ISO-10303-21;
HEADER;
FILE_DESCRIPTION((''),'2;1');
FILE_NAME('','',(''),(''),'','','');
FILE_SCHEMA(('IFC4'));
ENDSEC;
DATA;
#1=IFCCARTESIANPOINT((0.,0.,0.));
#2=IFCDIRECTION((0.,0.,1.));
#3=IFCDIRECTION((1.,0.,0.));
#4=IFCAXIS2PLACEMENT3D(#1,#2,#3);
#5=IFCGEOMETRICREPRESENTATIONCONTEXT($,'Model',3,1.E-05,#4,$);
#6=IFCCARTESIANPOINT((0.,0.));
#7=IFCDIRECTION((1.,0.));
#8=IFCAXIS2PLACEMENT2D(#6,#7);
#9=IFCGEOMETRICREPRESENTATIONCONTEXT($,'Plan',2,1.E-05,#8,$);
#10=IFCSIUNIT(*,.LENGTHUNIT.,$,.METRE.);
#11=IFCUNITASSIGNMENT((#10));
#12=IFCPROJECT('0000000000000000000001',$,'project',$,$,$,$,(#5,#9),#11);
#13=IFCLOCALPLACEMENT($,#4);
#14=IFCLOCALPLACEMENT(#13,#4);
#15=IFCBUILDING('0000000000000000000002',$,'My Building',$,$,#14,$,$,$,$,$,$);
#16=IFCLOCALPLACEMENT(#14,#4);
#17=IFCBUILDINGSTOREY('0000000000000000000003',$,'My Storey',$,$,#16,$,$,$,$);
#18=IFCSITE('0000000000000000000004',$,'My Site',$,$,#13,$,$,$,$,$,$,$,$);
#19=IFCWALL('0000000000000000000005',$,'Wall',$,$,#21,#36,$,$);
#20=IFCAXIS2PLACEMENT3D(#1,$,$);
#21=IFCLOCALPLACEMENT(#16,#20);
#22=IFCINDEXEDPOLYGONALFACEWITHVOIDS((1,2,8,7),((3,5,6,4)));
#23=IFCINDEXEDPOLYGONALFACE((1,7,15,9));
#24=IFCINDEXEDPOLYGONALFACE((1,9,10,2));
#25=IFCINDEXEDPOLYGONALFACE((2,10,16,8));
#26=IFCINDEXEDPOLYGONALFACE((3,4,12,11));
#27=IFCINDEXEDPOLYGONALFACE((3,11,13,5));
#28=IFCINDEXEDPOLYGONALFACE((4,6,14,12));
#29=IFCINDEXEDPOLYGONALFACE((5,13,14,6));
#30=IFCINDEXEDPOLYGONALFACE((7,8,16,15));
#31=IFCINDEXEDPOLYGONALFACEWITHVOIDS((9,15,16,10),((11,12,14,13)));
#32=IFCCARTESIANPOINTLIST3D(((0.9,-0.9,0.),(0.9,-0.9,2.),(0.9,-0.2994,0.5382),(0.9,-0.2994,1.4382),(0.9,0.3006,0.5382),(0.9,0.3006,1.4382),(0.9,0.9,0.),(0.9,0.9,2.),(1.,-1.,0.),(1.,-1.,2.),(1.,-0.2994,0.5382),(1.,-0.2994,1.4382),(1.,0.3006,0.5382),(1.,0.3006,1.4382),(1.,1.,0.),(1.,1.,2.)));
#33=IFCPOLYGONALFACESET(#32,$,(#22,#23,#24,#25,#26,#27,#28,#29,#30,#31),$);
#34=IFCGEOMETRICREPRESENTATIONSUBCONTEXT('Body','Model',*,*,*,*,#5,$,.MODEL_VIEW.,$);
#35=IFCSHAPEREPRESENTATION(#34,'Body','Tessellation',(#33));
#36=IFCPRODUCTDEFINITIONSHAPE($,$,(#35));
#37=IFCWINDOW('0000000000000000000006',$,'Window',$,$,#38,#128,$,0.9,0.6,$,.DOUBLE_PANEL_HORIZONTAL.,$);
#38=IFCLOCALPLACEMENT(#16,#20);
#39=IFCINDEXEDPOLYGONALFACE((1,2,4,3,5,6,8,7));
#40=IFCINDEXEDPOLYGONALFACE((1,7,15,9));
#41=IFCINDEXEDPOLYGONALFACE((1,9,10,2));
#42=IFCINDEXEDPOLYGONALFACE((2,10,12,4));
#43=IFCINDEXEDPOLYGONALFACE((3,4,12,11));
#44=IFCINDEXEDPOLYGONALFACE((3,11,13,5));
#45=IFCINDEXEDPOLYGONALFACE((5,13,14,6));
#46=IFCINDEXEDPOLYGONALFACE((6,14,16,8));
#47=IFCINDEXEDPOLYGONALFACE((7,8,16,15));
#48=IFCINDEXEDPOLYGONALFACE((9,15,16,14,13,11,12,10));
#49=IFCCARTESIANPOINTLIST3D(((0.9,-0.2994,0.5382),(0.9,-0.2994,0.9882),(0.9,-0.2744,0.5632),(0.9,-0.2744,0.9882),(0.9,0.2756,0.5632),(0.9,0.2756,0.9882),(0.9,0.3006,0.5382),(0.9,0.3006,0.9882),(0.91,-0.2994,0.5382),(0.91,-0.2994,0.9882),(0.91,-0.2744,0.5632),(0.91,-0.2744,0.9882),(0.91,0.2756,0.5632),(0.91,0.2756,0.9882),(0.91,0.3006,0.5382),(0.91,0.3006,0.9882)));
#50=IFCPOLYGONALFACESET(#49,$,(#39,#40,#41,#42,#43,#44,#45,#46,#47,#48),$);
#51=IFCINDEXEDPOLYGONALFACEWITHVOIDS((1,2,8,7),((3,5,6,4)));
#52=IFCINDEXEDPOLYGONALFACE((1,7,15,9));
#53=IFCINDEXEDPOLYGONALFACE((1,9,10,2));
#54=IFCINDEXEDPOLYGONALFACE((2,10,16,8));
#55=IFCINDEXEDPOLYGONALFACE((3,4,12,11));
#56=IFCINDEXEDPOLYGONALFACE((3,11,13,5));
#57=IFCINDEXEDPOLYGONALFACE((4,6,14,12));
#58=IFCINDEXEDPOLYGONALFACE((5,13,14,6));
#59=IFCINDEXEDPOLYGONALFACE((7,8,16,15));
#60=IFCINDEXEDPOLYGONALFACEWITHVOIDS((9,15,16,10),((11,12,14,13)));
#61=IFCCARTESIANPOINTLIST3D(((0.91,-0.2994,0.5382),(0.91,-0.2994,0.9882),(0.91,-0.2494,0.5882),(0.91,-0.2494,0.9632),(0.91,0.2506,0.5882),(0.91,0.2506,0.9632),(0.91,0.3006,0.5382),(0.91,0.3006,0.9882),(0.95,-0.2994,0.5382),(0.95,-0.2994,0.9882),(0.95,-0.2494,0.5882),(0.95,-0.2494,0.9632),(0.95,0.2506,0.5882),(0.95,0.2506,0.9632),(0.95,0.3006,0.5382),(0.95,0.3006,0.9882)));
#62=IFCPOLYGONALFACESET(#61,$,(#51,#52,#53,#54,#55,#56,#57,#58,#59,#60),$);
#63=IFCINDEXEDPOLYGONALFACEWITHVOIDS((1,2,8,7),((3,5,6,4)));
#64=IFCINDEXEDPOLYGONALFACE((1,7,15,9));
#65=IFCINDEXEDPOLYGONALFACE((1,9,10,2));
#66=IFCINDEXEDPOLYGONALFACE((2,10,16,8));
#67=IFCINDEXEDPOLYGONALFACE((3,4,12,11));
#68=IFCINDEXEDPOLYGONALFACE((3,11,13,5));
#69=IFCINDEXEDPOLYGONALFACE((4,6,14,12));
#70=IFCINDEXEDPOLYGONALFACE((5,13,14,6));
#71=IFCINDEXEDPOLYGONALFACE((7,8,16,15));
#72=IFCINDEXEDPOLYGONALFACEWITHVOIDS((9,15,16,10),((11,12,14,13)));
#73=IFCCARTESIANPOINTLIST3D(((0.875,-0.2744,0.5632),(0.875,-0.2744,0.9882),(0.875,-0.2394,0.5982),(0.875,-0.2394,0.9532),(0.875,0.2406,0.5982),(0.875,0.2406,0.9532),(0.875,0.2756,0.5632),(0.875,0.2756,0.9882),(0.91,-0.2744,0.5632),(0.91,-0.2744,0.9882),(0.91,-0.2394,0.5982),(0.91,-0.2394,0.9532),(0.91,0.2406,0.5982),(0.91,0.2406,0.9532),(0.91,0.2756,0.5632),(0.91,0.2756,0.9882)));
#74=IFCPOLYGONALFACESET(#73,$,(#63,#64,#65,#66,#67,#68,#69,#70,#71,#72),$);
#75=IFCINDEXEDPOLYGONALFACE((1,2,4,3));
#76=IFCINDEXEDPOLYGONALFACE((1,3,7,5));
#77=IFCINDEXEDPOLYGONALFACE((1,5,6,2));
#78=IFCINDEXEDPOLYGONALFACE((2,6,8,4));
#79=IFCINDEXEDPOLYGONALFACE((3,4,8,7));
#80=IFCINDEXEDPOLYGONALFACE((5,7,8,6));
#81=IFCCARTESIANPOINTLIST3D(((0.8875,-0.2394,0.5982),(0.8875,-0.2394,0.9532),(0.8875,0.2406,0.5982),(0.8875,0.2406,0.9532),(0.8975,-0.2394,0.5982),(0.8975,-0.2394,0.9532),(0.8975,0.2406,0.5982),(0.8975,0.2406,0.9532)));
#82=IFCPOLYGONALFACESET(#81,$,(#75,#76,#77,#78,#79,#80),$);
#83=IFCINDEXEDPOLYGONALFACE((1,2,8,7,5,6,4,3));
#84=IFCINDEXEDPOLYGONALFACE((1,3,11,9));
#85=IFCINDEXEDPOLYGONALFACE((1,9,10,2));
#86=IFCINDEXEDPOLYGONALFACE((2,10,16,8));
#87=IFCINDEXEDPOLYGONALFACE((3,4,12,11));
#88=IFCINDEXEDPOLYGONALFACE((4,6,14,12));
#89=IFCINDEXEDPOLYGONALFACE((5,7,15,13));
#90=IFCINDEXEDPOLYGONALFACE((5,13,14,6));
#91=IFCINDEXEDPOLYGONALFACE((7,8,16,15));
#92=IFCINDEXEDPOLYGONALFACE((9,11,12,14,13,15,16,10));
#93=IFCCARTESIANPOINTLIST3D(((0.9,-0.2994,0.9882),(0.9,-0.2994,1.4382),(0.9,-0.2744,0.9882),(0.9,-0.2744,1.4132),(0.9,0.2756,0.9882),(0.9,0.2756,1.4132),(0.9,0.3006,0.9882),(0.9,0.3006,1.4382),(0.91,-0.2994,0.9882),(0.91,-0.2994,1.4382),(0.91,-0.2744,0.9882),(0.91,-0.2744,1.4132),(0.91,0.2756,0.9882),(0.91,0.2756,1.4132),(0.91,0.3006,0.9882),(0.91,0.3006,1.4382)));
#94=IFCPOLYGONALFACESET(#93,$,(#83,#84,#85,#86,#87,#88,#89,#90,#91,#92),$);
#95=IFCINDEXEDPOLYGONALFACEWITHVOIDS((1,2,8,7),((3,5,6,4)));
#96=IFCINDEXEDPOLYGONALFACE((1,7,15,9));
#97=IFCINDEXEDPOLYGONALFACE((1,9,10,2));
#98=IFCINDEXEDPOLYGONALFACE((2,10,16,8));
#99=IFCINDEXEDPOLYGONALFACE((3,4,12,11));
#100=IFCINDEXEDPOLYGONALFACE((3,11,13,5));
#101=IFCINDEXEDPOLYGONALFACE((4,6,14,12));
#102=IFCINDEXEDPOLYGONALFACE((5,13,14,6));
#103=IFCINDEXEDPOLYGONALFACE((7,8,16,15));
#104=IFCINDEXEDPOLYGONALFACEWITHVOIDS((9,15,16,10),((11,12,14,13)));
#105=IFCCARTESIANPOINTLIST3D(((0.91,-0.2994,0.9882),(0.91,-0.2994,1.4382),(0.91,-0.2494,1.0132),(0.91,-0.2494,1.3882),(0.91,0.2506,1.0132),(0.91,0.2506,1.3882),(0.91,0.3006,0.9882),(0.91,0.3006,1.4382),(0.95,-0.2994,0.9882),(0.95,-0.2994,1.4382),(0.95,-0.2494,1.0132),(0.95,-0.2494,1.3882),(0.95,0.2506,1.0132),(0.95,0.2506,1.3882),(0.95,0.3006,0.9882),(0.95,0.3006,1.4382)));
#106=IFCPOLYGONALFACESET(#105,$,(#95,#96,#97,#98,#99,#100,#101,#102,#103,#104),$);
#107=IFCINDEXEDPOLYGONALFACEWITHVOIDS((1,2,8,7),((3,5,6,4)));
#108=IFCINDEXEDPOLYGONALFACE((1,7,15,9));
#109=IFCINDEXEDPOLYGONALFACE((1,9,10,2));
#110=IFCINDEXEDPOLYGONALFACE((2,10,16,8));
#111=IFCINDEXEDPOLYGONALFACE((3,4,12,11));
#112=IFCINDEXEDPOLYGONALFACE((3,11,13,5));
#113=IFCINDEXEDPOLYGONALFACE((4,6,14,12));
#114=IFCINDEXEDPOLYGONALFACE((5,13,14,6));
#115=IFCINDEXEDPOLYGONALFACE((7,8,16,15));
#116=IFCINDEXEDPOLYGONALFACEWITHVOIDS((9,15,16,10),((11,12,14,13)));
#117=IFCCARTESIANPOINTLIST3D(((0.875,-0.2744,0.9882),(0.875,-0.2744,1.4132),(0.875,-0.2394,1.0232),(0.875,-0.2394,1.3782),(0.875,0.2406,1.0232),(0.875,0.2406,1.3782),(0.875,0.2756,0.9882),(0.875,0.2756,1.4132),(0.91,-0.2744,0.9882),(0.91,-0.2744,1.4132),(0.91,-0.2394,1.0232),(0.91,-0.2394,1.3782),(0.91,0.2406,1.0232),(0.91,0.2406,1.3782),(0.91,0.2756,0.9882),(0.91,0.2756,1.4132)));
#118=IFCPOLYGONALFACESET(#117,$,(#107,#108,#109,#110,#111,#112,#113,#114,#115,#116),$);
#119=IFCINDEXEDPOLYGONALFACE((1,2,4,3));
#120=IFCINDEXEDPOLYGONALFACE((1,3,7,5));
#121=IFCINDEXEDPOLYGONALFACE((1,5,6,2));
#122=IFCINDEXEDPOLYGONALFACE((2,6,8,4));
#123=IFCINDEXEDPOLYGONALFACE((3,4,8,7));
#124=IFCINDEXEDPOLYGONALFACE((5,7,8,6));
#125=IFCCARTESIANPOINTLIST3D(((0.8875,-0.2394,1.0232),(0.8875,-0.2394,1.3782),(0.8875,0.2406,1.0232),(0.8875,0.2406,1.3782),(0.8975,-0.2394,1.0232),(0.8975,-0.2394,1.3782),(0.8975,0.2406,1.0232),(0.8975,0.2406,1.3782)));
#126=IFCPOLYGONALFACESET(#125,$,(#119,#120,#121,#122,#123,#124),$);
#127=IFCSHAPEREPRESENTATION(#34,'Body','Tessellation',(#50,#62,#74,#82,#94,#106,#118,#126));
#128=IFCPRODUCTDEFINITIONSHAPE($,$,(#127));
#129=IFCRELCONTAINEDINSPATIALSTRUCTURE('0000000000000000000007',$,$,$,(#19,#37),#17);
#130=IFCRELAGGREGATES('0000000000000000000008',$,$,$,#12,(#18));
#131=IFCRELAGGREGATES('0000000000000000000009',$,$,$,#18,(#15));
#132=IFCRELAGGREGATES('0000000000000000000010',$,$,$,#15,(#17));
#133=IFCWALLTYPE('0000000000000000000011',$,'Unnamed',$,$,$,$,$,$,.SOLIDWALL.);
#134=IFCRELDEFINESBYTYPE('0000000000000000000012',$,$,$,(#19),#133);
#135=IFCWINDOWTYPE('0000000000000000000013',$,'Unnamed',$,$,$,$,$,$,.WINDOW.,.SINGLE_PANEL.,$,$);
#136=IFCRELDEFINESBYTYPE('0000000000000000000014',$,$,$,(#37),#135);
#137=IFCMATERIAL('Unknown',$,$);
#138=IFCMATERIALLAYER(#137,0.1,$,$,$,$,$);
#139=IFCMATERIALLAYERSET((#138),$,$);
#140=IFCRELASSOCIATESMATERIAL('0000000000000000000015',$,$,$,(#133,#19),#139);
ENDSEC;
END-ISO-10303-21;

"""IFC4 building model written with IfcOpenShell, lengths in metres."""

from ifc_helpers import new_model, entity, si_unit, frame, origin_with_axes, origin_2d_with_axis, place, context, subcontext, project, spatial, line, indexed_curve, outline, extrude, shape, source, transform, mapped, material, layer, layer_set, layer_usage, type_object, type_shapes, element, fill, save


model = new_model("IFC4")

# Units and contexts
model_context = context("Model", 3, precision=1e-05, world=origin_with_axes())
plan_context = context("Plan", 2, precision=1e-05, world=origin_2d_with_axis())
body_context_1 = subcontext(model_context, "Body", "Model", "MODEL_VIEW")
body_context_2 = subcontext(plan_context, "Body", "Plan", "PLAN_VIEW")
ifc_project = project(units=[si_unit("LENGTHUNIT", "METRE")], contexts=[model_context, plan_context])

# Site, building, storey
site_placement = place(None, origin_with_axes())
site = spatial("IfcSite", under=ifc_project, at=site_placement, Name="My Site")
building_placement = place(site_placement, origin_with_axes())
building = spatial("IfcBuilding", under=site, at=building_placement, Name="My Building")
storey_placement = place(building_placement, origin_with_axes())
storey = spatial("IfcBuildingStorey", under=building, at=storey_placement, Name="My Storey")

# Shared definitions
ifc_material = material(Name="Unknown")

# Shared definitions
ifc_layer = layer(ifc_material, 0.1)
ifc_layer_set = layer_set([ifc_layer])
wall_type = type_object("IfcWallType", Name="Unnamed", PredefinedType="SOLIDWALL", material=ifc_layer_set)

# Wall, opening, window
ifc_layer_usage_1 = layer_usage(ifc_layer_set, "AXIS2", "POSITIVE", 0.0)
wall_1_placement = place(storey_placement, frame((0.9, 0.9, 0.0), z_axis=(0.0, 0.0, 1.0), x_axis=(0.0, -1.0, 0.0)))
wall_1 = element("IfcWall", 1, at=wall_1_placement, inside=storey, type_object=wall_type, material=ifc_layer_usage_1, Name="Wall", context=body_context_1, shape_type="SweptSolid", body=[
    extrude(outline(indexed_curve([(0.0, 0.0), (-0.1, 0.1), (1.9, 0.1), (1.8, 0.0)], segments=[line(1, 2, 3, 4, 1)])), origin_with_axes(), (0.0, 0.0, 1.0), 2.0),
])
shared_shape_1 = source(origin_with_axes(), body_context_1, "Body", "SweptSolid", [
    extrude(outline(indexed_curve([(0.0, 0.0), (0.6, 0.0), (0.6, 0.9), (0.0, 0.9)], segments=[line(1, 2, 3, 4, 1)])), frame((0.0, -0.6, 0.0), z_axis=(0.0, -1.0, 0.0), x_axis=(1.0, 0.0, 0.0)), (0.0, 0.0, -1.0), 1.2),
])
opening_1_placement = place(wall_1_placement, frame((1.1994, 0.1, 0.5382), z_axis=(0.0, 0.0, 1.0), x_axis=(-1.0, 0.0, 0.0)))
opening_1 = element("IfcOpeningElement", 2, at=opening_1_placement, cuts=wall_1, PredefinedType="OPENING", context=body_context_1, shape_type="MappedRepresentation", body=[
    mapped(shared_shape_1, transform((0.0, 0.0, 0.0), x_axis=(1.0, 0.0, 0.0), y_axis=(0.0, 1.0, 0.0), z_axis=(0.0, 0.0, 1.0), scale=1.0)),
])
window_type = type_object("IfcWindowType", Name="Unnamed", PartitioningType="SINGLE_PANEL", PredefinedType="WINDOW")
shared_shape_2 = source(origin_with_axes(), body_context_1, "Body", "SweptSolid", [
    extrude(outline(indexed_curve([(0.6, 0.45), (0.6, 0.0), (0.0, 0.0), (0.0, 0.45), (0.025, 0.45), (0.025, 0.025), (0.575, 0.025), (0.575, 0.45)], segments=[line(1, 2, 3, 4, 5, 6, 7, 8, 1)])), frame((0.0, 0.09, 0.0), z_axis=(0.0, -1.0, 0.0), x_axis=(1.0, 0.0, 0.0)), (0.0, 0.0, -1.0), 0.01),
    extrude(outline(indexed_curve([(0.0, 0.0), (0.6, 0.0), (0.6, 0.45), (0.0, 0.45)], segments=[line(1, 2, 3, 4, 1)]), holes=[indexed_curve([(0.05, 0.05), (0.55, 0.05), (0.55, 0.425), (0.05, 0.425)], segments=[line(1, 2, 3, 4, 1)])]), frame((0.0, 0.05, 0.0), z_axis=(0.0, -1.0, 0.0), x_axis=(1.0, 0.0, 0.0)), (0.0, 0.0, -1.0), 0.04),
    extrude(outline(indexed_curve([(0.0, 0.0), (0.55, 0.0), (0.55, 0.425), (0.0, 0.425)], segments=[line(1, 2, 3, 4, 1)]), holes=[indexed_curve([(0.035, 0.035), (0.515, 0.035), (0.515, 0.39), (0.035, 0.39)], segments=[line(1, 2, 3, 4, 1)])]), frame((0.025, 0.09, 0.025), z_axis=(0.0, -1.0, 0.0), x_axis=(1.0, 0.0, 0.0)), (0.0, 0.0, -1.0), 0.035),
    extrude(outline(indexed_curve([(0.035, 0.035), (0.515, 0.035), (0.515, 0.39), (0.035, 0.39)], segments=[line(1, 2, 3, 4, 1)])), frame((0.025, 0.1025, 0.025), z_axis=(0.0, -1.0, 0.0), x_axis=(1.0, 0.0, 0.0)), (0.0, 0.0, -1.0), 0.01),
    extrude(outline(indexed_curve([(0.0, 0.0), (0.0, 0.45), (0.6, 0.45), (0.6, 0.0), (0.575, 0.0), (0.575, 0.425), (0.025, 0.425), (0.025, 0.0)], segments=[line(1, 2, 3, 4, 5, 6, 7, 8, 1)])), frame((0.0, 0.09, 0.45), z_axis=(0.0, -1.0, 0.0), x_axis=(1.0, 0.0, 0.0)), (0.0, 0.0, -1.0), 0.01),
    extrude(outline(indexed_curve([(0.0, 0.0), (0.6, 0.0), (0.6, 0.45), (0.0, 0.45)], segments=[line(1, 2, 3, 4, 1)]), holes=[indexed_curve([(0.05, 0.025), (0.55, 0.025), (0.55, 0.4), (0.05, 0.4)], segments=[line(1, 2, 3, 4, 1)])]), frame((0.0, 0.05, 0.45), z_axis=(0.0, -1.0, 0.0), x_axis=(1.0, 0.0, 0.0)), (0.0, 0.0, -1.0), 0.04),
    extrude(outline(indexed_curve([(0.0, 0.0), (0.55, 0.0), (0.55, 0.425), (0.0, 0.425)], segments=[line(1, 2, 3, 4, 1)]), holes=[indexed_curve([(0.035, 0.035), (0.515, 0.035), (0.515, 0.39), (0.035, 0.39)], segments=[line(1, 2, 3, 4, 1)])]), frame((0.025, 0.09, 0.45), z_axis=(0.0, -1.0, 0.0), x_axis=(1.0, 0.0, 0.0)), (0.0, 0.0, -1.0), 0.035),
    extrude(outline(indexed_curve([(0.035, 0.035), (0.515, 0.035), (0.515, 0.39), (0.035, 0.39)], segments=[line(1, 2, 3, 4, 1)])), frame((0.025, 0.1025, 0.45), z_axis=(0.0, -1.0, 0.0), x_axis=(1.0, 0.0, 0.0)), (0.0, 0.0, -1.0), 0.01),
])
shared_shape_3 = source(origin_with_axes(), body_context_2, "Body", "Curve2D", [
    entity("IfcIndexedPolyCurve", entity("IfcCartesianPointList2D", [[0.05, 0.05], [0.55, 0.05]])),
    entity("IfcIndexedPolyCurve", entity("IfcCartesianPointList2D", [[0.0, 0.1], [0.025, 0.1], [0.025, 0.09], [0.05, 0.09], [0.05, 0.05], [0.0, 0.05]]), [entity("IfcLineIndex", [1, 2, 3, 4, 5, 6, 1])]),
    entity("IfcIndexedPolyCurve", entity("IfcCartesianPointList2D", [[0.6, 0.1], [0.575, 0.1], [0.575, 0.09], [0.55, 0.09], [0.55, 0.05], [0.6, 0.05]]), [entity("IfcLineIndex", [1, 2, 3, 4, 5, 6, 1])]),
    entity("IfcIndexedPolyCurve", entity("IfcCartesianPointList2D", [[0.025, 0.09], [0.06, 0.09], [0.06, 0.125], [0.025, 0.125]]), [entity("IfcLineIndex", [1, 2, 3, 4, 1])]),
    entity("IfcIndexedPolyCurve", entity("IfcCartesianPointList2D", [[0.575, 0.09], [0.54, 0.09], [0.54, 0.125], [0.575, 0.125]]), [entity("IfcLineIndex", [1, 2, 3, 4, 1])]),
    entity("IfcIndexedPolyCurve", entity("IfcCartesianPointList2D", [[0.06, 0.09], [0.54, 0.09]])),
    entity("IfcIndexedPolyCurve", entity("IfcCartesianPointList2D", [[0.06, 0.125], [0.54, 0.125]])),
    entity("IfcIndexedPolyCurve", entity("IfcCartesianPointList2D", [[0.06, 0.1075], [0.54, 0.1075]])),
])
type_shapes(window_type, [shared_shape_2, shared_shape_3])
window_1_placement = place(opening_1_placement, frame((0.0, 0.0, 0.0), z_axis=(0.0, 0.0, 1.0), x_axis=(1.0, 0.0, 0.0)))
window_1 = element("IfcWindow", 3, at=window_1_placement, inside=storey, type_object=window_type, Name="Window", OverallHeight=0.9, OverallWidth=0.6, PartitioningType="DOUBLE_PANEL_HORIZONTAL", shapes=[
    shape(body_context_1, "Body", "MappedRepresentation", [mapped(shared_shape_2, transform((0.0, 0.0, 0.0), x_axis=(1.0, 0.0, 0.0), y_axis=(0.0, 1.0, 0.0), z_axis=(0.0, 0.0, 1.0), scale=1.0))]),
    shape(body_context_2, "Body", "MappedRepresentation", [mapped(shared_shape_3, transform((0.0, 0.0, 0.0), x_axis=(1.0, 0.0, 0.0), y_axis=(0.0, 1.0, 0.0), z_axis=(0.0, 0.0, 1.0), scale=1.0))]),
])
fill(opening_1, window_1)

save(model, "model.ifc")
